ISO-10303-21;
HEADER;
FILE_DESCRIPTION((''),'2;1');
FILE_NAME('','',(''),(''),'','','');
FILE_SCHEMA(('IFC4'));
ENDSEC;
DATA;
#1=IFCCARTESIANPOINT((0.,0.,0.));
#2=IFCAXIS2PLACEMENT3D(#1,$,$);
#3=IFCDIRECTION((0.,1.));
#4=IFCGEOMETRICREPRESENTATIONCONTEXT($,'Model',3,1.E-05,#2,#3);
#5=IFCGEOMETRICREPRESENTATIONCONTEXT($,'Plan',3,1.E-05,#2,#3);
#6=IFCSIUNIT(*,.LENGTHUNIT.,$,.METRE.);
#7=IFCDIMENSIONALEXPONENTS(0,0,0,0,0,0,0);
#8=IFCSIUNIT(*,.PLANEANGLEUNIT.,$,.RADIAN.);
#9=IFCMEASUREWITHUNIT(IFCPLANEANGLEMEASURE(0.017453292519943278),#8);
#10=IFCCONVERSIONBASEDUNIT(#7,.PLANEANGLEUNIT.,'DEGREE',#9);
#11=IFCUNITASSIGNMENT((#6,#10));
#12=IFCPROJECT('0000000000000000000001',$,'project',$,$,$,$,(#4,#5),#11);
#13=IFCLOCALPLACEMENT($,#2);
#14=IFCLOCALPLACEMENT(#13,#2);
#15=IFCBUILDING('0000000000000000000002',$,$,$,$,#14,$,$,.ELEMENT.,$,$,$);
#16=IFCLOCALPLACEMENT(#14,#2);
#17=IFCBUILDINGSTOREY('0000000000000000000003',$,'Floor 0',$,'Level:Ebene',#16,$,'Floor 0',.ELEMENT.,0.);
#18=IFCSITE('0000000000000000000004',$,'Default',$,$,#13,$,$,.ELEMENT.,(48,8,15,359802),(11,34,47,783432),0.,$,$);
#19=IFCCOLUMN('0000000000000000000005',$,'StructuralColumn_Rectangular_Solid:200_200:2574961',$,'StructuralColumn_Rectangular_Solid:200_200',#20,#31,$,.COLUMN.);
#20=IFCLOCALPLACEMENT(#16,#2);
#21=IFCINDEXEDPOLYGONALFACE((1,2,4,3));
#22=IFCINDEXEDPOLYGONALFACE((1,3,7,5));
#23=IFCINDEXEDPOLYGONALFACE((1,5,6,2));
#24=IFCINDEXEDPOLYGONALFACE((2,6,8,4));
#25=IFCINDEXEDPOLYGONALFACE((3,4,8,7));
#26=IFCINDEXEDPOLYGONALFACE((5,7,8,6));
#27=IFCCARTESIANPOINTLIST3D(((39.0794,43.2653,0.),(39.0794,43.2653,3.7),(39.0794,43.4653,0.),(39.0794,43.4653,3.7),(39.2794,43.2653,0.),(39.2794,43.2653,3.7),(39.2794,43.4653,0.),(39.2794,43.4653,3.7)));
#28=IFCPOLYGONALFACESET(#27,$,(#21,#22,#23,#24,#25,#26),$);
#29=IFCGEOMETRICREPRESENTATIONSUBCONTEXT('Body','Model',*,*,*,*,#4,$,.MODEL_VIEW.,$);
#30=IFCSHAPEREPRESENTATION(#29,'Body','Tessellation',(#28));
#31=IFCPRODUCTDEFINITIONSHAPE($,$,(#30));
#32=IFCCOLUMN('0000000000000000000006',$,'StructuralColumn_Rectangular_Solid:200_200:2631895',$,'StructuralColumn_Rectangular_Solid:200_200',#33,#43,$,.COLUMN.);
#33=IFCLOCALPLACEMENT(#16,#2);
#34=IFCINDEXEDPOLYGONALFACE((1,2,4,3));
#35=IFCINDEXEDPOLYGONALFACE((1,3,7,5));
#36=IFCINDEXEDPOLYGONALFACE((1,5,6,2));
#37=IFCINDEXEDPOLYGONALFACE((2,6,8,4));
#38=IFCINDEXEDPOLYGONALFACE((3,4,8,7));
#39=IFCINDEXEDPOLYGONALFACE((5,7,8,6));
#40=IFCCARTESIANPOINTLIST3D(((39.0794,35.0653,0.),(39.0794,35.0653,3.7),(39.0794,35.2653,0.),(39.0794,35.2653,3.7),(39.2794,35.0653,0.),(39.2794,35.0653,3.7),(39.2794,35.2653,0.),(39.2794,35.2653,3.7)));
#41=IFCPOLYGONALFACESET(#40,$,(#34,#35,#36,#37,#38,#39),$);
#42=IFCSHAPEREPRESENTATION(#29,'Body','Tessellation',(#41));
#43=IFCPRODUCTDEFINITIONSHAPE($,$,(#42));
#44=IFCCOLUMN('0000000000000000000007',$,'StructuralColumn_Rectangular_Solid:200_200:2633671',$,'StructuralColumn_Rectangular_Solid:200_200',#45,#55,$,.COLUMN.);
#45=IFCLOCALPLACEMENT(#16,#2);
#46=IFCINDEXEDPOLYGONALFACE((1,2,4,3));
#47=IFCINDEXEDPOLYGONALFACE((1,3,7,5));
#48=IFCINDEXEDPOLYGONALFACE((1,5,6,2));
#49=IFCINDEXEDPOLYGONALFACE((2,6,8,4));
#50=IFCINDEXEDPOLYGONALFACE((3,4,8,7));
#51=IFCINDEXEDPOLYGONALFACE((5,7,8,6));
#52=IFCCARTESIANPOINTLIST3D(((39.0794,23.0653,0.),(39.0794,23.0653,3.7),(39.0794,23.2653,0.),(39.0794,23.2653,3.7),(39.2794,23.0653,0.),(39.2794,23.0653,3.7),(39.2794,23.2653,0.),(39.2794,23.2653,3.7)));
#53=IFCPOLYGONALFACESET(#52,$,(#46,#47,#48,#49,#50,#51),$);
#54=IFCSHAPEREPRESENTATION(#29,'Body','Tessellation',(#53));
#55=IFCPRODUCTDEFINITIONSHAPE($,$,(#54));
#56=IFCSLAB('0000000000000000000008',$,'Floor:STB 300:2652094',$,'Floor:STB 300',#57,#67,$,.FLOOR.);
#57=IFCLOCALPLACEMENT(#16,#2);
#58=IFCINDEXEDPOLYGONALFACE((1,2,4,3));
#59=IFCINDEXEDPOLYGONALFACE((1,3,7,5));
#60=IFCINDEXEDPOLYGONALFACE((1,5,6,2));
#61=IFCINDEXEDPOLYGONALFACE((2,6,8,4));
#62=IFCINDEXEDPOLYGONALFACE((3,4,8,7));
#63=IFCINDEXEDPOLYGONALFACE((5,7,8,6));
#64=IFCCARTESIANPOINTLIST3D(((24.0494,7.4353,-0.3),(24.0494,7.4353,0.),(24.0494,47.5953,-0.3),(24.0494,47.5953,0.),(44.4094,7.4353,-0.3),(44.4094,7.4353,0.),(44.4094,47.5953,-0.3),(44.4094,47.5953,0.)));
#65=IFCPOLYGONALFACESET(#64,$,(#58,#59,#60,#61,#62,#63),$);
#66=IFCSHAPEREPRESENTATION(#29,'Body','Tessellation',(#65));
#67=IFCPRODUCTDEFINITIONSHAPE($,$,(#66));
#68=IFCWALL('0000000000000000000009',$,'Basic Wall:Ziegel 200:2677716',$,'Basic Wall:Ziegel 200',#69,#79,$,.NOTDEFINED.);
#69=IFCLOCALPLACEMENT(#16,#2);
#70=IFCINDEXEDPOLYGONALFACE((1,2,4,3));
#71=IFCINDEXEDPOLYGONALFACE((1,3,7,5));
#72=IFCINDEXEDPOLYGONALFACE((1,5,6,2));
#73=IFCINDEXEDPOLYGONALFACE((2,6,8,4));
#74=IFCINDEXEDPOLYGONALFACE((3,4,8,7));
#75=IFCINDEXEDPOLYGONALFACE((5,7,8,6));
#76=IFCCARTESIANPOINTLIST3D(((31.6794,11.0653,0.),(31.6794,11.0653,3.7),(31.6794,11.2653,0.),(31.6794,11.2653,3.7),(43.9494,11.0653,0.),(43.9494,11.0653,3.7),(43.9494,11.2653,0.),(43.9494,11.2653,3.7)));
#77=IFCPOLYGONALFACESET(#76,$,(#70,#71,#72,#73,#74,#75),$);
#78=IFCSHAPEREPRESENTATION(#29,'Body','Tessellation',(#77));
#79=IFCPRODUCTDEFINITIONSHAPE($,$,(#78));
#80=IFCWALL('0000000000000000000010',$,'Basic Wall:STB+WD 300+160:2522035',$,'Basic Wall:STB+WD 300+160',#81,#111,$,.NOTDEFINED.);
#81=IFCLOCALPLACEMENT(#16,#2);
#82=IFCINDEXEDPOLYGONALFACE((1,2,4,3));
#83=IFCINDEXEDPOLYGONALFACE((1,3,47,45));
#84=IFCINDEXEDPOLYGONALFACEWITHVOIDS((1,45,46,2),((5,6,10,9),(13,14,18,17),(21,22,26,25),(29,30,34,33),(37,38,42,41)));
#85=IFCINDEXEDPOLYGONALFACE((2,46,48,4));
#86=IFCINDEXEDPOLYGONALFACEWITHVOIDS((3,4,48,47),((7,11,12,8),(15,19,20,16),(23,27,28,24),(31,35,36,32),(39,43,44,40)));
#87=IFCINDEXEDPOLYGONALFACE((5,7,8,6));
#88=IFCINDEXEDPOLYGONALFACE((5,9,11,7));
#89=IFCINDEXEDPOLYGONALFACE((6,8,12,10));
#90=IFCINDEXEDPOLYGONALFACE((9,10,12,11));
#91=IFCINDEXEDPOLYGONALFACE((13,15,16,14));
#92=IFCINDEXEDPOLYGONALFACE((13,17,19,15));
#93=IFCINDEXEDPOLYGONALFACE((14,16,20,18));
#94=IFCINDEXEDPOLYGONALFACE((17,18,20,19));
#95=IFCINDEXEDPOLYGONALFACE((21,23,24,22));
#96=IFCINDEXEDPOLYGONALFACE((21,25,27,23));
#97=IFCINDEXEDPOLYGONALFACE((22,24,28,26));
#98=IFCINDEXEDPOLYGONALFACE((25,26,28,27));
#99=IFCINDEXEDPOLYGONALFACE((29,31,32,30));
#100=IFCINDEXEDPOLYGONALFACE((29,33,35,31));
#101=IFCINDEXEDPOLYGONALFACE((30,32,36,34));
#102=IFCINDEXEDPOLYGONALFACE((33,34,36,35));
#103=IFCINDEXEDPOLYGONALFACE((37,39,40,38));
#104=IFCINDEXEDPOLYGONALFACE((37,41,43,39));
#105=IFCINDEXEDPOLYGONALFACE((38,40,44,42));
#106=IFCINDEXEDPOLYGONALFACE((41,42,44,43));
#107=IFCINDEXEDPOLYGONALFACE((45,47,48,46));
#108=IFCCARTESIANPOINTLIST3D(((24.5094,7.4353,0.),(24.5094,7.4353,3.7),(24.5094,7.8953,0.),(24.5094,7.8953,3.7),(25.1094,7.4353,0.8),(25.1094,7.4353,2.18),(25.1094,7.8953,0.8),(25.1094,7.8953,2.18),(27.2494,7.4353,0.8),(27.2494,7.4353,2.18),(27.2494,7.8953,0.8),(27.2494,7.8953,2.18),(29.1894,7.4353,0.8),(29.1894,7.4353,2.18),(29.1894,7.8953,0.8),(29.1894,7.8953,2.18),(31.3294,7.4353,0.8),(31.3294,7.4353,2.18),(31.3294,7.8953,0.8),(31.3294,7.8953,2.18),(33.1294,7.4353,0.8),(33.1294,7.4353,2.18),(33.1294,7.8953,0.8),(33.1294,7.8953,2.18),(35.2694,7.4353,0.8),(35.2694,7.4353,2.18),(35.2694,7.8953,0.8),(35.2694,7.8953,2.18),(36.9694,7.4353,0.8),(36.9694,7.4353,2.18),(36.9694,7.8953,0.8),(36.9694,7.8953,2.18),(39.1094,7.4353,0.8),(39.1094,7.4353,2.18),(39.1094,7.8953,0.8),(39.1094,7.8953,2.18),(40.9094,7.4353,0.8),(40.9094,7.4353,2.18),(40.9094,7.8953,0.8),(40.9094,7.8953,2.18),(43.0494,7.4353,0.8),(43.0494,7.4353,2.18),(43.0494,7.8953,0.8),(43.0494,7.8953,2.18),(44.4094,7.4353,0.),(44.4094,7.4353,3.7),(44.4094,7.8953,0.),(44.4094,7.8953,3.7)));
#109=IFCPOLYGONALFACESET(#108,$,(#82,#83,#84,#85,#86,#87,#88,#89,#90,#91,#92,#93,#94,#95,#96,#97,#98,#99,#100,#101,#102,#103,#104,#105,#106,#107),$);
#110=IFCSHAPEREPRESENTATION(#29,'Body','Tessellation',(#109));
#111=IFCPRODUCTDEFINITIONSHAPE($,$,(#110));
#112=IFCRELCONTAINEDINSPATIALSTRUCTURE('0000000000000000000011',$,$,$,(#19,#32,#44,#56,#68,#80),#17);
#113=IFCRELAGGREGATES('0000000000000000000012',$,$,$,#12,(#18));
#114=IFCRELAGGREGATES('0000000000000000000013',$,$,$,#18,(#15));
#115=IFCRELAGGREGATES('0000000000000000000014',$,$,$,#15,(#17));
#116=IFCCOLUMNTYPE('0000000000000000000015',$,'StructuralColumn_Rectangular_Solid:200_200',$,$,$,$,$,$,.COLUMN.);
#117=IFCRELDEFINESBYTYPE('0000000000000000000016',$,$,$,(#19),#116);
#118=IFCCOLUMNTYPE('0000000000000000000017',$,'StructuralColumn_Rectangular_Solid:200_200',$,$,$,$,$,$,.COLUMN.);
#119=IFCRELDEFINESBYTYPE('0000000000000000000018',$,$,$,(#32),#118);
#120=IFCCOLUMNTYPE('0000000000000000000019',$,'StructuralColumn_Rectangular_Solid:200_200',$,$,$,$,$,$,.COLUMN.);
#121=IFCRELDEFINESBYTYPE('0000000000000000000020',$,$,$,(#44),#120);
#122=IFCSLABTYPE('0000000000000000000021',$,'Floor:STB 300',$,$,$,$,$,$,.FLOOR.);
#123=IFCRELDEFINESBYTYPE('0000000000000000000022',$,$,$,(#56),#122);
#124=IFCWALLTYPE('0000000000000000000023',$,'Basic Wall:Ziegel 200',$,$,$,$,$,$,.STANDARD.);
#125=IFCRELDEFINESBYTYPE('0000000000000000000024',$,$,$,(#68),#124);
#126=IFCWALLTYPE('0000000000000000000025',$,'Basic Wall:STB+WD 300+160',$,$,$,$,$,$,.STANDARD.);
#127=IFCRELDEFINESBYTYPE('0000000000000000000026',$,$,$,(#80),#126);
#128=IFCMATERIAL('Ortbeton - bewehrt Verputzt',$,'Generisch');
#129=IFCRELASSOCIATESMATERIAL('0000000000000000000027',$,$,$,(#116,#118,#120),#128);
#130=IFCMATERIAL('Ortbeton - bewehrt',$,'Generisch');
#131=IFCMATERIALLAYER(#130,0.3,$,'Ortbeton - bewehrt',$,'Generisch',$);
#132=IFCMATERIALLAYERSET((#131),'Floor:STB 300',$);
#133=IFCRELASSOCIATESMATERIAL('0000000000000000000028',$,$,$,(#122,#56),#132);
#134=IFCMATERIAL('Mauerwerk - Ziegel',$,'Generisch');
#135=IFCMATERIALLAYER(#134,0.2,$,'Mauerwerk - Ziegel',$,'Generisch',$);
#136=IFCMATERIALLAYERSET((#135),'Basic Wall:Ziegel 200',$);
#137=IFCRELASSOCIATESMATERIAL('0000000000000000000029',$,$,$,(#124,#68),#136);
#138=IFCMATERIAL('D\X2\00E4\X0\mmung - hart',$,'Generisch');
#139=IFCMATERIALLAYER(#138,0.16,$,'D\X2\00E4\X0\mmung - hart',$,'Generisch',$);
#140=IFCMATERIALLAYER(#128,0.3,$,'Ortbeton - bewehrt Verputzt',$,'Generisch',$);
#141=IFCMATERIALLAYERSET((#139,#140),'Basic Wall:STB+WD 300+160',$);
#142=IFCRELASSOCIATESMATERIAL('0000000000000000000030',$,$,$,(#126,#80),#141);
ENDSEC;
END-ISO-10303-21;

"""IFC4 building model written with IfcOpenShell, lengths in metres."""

from ifc_helpers import new_model, entity, si_unit, converted_unit, direction, frame, frame_2d, origin, place, context, subcontext, project, spatial, rectangle, extrude, source, transform, mapped, material, layer, layer_set, layer_usage, material_profile, profile_set, type_object, type_shapes, element, save


model = new_model("IFC4")

# Units and contexts
model_context = context("Model", 3, precision=1e-05, world=origin(), true_north=direction((0.0, 1.0)))
plan_context = context("Plan", 3, precision=1e-05, world=origin(), true_north=direction((0.0, 1.0)))
body_context = subcontext(model_context, "Body", "Model", "MODEL_VIEW")
ifc_project = project(units=[si_unit("LENGTHUNIT", "METRE"), converted_unit("PLANEANGLEUNIT", "DEGREE", entity("IfcPlaneAngleMeasure", 0.017453292519943278), si_unit("PLANEANGLEUNIT", "RADIAN"), dimensions=[0, 0, 0, 0, 0, 0, 0])], contexts=[model_context, plan_context])

# Site, building, storey
site_placement = place(None, origin())
site = spatial("IfcSite", under=ifc_project, at=site_placement, Name="Default", CompositionType="ELEMENT", RefLatitude=(48, 8, 15, 359802), RefLongitude=(11, 34, 47, 783432), RefElevation=0.0)
building_placement = place(site_placement, origin())
building = spatial("IfcBuilding", under=site, at=building_placement, CompositionType="ELEMENT")
storey_placement = place(building_placement, origin())
storey = spatial("IfcBuildingStorey", under=building, at=storey_placement, Name="Floor 0", ObjectType="Level:Ebene", LongName="Floor 0", CompositionType="ELEMENT", Elevation=0.0)

# Columns
ifc_material_1 = material(Name="Ortbeton - bewehrt Verputzt", Category="Generisch")
ifc_material_profile = material_profile(ifc_material_1, rectangle(XDim=0.2, YDim=0.2, at=frame_2d((0.0, 0.0), x_axis=(1.0, 0.0))), Name="200_200")
ifc_profile_set = profile_set([ifc_material_profile], Name="200_200")
column_type_1 = type_object("IfcColumnType", Name="StructuralColumn_Rectangular_Solid:200_200", PredefinedType="COLUMN", material=ifc_profile_set)
shared_shape_1 = source(origin(), body_context, "Body", "SweptSolid", [
    extrude(rectangle(XDim=0.2, YDim=0.2, at=frame_2d((0.0, 0.0), x_axis=(1.0, 0.0))), frame((39.1794, 43.3653, 0.0), z_axis=(0.0, 0.0, 1.0), x_axis=(-1.0, 0.0, 0.0)), (0.0, 0.0, 1.0), 3.7),
])
type_shapes(column_type_1, [shared_shape_1])
column_1_placement = place(storey_placement, origin())
element("IfcColumn", 1, at=column_1_placement, inside=storey, type_object=column_type_1, Name="StructuralColumn_Rectangular_Solid:200_200:2574961", ObjectType="StructuralColumn_Rectangular_Solid:200_200", PredefinedType="COLUMN", context=body_context, shape_type="MappedRepresentation", body=[
    mapped(shared_shape_1, transform((0.0, 0.0, 0.0), scale=1.0)),
])
column_type_2 = type_object("IfcColumnType", Name="StructuralColumn_Rectangular_Solid:200_200", PredefinedType="COLUMN", material=ifc_profile_set)
shared_shape_2 = source(origin(), body_context, "Body", "SweptSolid", [
    extrude(rectangle(XDim=0.2, YDim=0.2, at=frame_2d((0.0, 0.0), x_axis=(1.0, 0.0))), frame((39.1794, 35.1653, 0.0), z_axis=(0.0, 0.0, 1.0), x_axis=(-1.0, 0.0, 0.0)), (0.0, 0.0, 1.0), 3.7),
])
type_shapes(column_type_2, [shared_shape_2])
column_2_placement = place(storey_placement, origin())
element("IfcColumn", 2, at=column_2_placement, inside=storey, type_object=column_type_2, Name="StructuralColumn_Rectangular_Solid:200_200:2631895", ObjectType="StructuralColumn_Rectangular_Solid:200_200", PredefinedType="COLUMN", context=body_context, shape_type="MappedRepresentation", body=[
    mapped(shared_shape_2, transform((0.0, 0.0, 0.0), scale=1.0)),
])
column_type_3 = type_object("IfcColumnType", Name="StructuralColumn_Rectangular_Solid:200_200", PredefinedType="COLUMN", material=ifc_profile_set)
shared_shape_3 = source(origin(), body_context, "Body", "SweptSolid", [
    extrude(rectangle(XDim=0.2, YDim=0.2, at=frame_2d((0.0, 0.0), x_axis=(1.0, 0.0))), frame((39.1794, 23.1653, 0.0), z_axis=(0.0, 0.0, 1.0), x_axis=(-1.0, 0.0, 0.0)), (0.0, 0.0, 1.0), 3.7),
])
type_shapes(column_type_3, [shared_shape_3])
column_3_placement = place(storey_placement, origin())
element("IfcColumn", 3, at=column_3_placement, inside=storey, type_object=column_type_3, Name="StructuralColumn_Rectangular_Solid:200_200:2633671", ObjectType="StructuralColumn_Rectangular_Solid:200_200", PredefinedType="COLUMN", context=body_context, shape_type="MappedRepresentation", body=[
    mapped(shared_shape_3, transform((0.0, 0.0, 0.0), scale=1.0)),
])

# Slab
ifc_material_2 = material(Name="Ortbeton - bewehrt", Category="Generisch")
ifc_layer_1 = layer(ifc_material_2, 0.3, Name="Ortbeton - bewehrt", Category="Generisch")
ifc_layer_set_1 = layer_set([ifc_layer_1], Name="Floor:STB 300")
ifc_layer_usage_1 = layer_usage(ifc_layer_set_1, "AXIS3", "POSITIVE", 0.0)
slab_type = type_object("IfcSlabType", Name="Floor:STB 300", PredefinedType="FLOOR", material=ifc_layer_set_1)
slab_placement = place(storey_placement, origin())
element("IfcSlab", 4, at=slab_placement, inside=storey, type_object=slab_type, material=ifc_layer_usage_1, Name="Floor:STB 300:2652094", ObjectType="Floor:STB 300", PredefinedType="FLOOR", context=body_context, shape_type="SweptSolid", body=[
    extrude(rectangle(XDim=40.16, YDim=20.36, at=frame_2d((0.0, 0.0), x_axis=(1.0, 0.0))), frame((34.2294, 27.5153, 0.0), z_axis=(0.0, 0.0, -1.0), x_axis=(0.0, 1.0, 0.0)), (0.0, 0.0, 1.0), 0.3),
])

# Wall
ifc_material_3 = material(Name="Mauerwerk - Ziegel", Category="Generisch")
ifc_layer_2 = layer(ifc_material_3, 0.2, Name="Mauerwerk - Ziegel", Category="Generisch")
ifc_layer_set_2 = layer_set([ifc_layer_2], Name="Basic Wall:Ziegel 200")
ifc_layer_usage_2 = layer_usage(ifc_layer_set_2, "AXIS2", "NEGATIVE", 0.1)
wall_type_1 = type_object("IfcWallType", Name="Basic Wall:Ziegel 200", PredefinedType="STANDARD", material=ifc_layer_set_2)
wall_1_placement = place(storey_placement, frame((43.9494, 11.1653, 0.0), z_axis=(0.0, 0.0, 1.0), x_axis=(-1.0, 0.0, 0.0)))
element("IfcWall", 5, at=wall_1_placement, inside=storey, type_object=wall_type_1, material=ifc_layer_usage_2, Name="Basic Wall:Ziegel 200:2677716", ObjectType="Basic Wall:Ziegel 200", PredefinedType="NOTDEFINED", context=body_context, shape_type="SweptSolid", body=[
    extrude(rectangle(XDim=12.27, YDim=0.2, at=frame_2d((6.135, 0.0), x_axis=(-1.0, 0.0))), origin(), (0.0, 0.0, 1.0), 3.7),
])

# Wall, openings
ifc_material_4 = material(Name="Dämmung - hart", Category="Generisch")
ifc_layer_3 = layer(ifc_material_4, 0.16, Name="Dämmung - hart", Category="Generisch")
ifc_layer_4 = layer(ifc_material_1, 0.3, Name="Ortbeton - bewehrt Verputzt", Category="Generisch")
ifc_layer_set_3 = layer_set([ifc_layer_3, ifc_layer_4], Name="Basic Wall:STB+WD 300+160")
ifc_layer_usage_3 = layer_usage(ifc_layer_set_3, "AXIS2", "POSITIVE", -0.23)
wall_type_2 = type_object("IfcWallType", Name="Basic Wall:STB+WD 300+160", PredefinedType="STANDARD", material=ifc_layer_set_3)
wall_2_placement = place(storey_placement, frame((24.5094, 7.6653, 0.0)))
wall_2 = element("IfcWall", 6, at=wall_2_placement, inside=storey, type_object=wall_type_2, material=ifc_layer_usage_3, Name="Basic Wall:STB+WD 300+160:2522035", ObjectType="Basic Wall:STB+WD 300+160", PredefinedType="NOTDEFINED", context=body_context, shape_type="SweptSolid", body=[
    extrude(rectangle(XDim=19.9, YDim=0.46, at=frame_2d((9.95, 0.0), x_axis=(-1.0, 0.0))), origin(), (0.0, 0.0, 1.0), 3.7),
])
opening_1_placement = place(wall_2_placement, frame((-24.5094, -7.6653, 0.8)))
element("IfcOpeningElement", 7, at=opening_1_placement, cuts=wall_2, PredefinedType="OPENING", context=body_context, shape_type="SweptSolid", body=[
    extrude(rectangle(XDim=1.38, YDim=2.14, at=frame_2d((0.0, 0.0), x_axis=(0.0, 1.0))), frame((41.9794, 6.3713, 0.69), z_axis=(0.0, 1.0, 0.0), x_axis=(-1.0, 0.0, 0.0)), (0.0, 0.0, 1.0), 3.048),
])
opening_2_placement = place(wall_2_placement, frame((-24.5094, -7.6653, 0.8)))
element("IfcOpeningElement", 8, at=opening_2_placement, cuts=wall_2, PredefinedType="OPENING", context=body_context, shape_type="SweptSolid", body=[
    extrude(rectangle(XDim=1.38, YDim=2.14, at=frame_2d((0.0, 0.0), x_axis=(0.0, 1.0))), frame((38.0394, 6.3713, 0.69), z_axis=(0.0, 1.0, 0.0), x_axis=(-1.0, 0.0, 0.0)), (0.0, 0.0, 1.0), 3.048),
])
opening_3_placement = place(wall_2_placement, frame((-24.5094, -7.6653, 0.8)))
element("IfcOpeningElement", 9, at=opening_3_placement, cuts=wall_2, PredefinedType="OPENING", context=body_context, shape_type="SweptSolid", body=[
    extrude(rectangle(XDim=1.38, YDim=2.14, at=frame_2d((0.0, 0.0), x_axis=(0.0, 1.0))), frame((34.1994, 6.3713, 0.69), z_axis=(0.0, 1.0, 0.0), x_axis=(-1.0, 0.0, 0.0)), (0.0, 0.0, 1.0), 3.048),
])
opening_4_placement = place(wall_2_placement, frame((-24.5094, -7.6653, 0.8)))
element("IfcOpeningElement", 10, at=opening_4_placement, cuts=wall_2, PredefinedType="OPENING", context=body_context, shape_type="SweptSolid", body=[
    extrude(rectangle(XDim=1.38, YDim=2.14, at=frame_2d((0.0, 0.0), x_axis=(0.0, 1.0))), frame((30.2594, 6.3713, 0.69), z_axis=(0.0, 1.0, 0.0), x_axis=(-1.0, 0.0, 0.0)), (0.0, 0.0, 1.0), 3.048),
])
opening_5_placement = place(wall_2_placement, frame((-24.5094, -7.6653, 0.8)))
element("IfcOpeningElement", 11, at=opening_5_placement, cuts=wall_2, PredefinedType="OPENING", context=body_context, shape_type="SweptSolid", body=[
    extrude(rectangle(XDim=1.38, YDim=2.14, at=frame_2d((0.0, 0.0), x_axis=(1.0, 0.0))), frame((26.1794, 5.9113, 0.69), z_axis=(0.0, 1.0, 0.0), x_axis=(0.0, 0.0, 1.0)), (0.0, 0.0, 1.0), 3.048),
])

save(model, "model.ifc")
